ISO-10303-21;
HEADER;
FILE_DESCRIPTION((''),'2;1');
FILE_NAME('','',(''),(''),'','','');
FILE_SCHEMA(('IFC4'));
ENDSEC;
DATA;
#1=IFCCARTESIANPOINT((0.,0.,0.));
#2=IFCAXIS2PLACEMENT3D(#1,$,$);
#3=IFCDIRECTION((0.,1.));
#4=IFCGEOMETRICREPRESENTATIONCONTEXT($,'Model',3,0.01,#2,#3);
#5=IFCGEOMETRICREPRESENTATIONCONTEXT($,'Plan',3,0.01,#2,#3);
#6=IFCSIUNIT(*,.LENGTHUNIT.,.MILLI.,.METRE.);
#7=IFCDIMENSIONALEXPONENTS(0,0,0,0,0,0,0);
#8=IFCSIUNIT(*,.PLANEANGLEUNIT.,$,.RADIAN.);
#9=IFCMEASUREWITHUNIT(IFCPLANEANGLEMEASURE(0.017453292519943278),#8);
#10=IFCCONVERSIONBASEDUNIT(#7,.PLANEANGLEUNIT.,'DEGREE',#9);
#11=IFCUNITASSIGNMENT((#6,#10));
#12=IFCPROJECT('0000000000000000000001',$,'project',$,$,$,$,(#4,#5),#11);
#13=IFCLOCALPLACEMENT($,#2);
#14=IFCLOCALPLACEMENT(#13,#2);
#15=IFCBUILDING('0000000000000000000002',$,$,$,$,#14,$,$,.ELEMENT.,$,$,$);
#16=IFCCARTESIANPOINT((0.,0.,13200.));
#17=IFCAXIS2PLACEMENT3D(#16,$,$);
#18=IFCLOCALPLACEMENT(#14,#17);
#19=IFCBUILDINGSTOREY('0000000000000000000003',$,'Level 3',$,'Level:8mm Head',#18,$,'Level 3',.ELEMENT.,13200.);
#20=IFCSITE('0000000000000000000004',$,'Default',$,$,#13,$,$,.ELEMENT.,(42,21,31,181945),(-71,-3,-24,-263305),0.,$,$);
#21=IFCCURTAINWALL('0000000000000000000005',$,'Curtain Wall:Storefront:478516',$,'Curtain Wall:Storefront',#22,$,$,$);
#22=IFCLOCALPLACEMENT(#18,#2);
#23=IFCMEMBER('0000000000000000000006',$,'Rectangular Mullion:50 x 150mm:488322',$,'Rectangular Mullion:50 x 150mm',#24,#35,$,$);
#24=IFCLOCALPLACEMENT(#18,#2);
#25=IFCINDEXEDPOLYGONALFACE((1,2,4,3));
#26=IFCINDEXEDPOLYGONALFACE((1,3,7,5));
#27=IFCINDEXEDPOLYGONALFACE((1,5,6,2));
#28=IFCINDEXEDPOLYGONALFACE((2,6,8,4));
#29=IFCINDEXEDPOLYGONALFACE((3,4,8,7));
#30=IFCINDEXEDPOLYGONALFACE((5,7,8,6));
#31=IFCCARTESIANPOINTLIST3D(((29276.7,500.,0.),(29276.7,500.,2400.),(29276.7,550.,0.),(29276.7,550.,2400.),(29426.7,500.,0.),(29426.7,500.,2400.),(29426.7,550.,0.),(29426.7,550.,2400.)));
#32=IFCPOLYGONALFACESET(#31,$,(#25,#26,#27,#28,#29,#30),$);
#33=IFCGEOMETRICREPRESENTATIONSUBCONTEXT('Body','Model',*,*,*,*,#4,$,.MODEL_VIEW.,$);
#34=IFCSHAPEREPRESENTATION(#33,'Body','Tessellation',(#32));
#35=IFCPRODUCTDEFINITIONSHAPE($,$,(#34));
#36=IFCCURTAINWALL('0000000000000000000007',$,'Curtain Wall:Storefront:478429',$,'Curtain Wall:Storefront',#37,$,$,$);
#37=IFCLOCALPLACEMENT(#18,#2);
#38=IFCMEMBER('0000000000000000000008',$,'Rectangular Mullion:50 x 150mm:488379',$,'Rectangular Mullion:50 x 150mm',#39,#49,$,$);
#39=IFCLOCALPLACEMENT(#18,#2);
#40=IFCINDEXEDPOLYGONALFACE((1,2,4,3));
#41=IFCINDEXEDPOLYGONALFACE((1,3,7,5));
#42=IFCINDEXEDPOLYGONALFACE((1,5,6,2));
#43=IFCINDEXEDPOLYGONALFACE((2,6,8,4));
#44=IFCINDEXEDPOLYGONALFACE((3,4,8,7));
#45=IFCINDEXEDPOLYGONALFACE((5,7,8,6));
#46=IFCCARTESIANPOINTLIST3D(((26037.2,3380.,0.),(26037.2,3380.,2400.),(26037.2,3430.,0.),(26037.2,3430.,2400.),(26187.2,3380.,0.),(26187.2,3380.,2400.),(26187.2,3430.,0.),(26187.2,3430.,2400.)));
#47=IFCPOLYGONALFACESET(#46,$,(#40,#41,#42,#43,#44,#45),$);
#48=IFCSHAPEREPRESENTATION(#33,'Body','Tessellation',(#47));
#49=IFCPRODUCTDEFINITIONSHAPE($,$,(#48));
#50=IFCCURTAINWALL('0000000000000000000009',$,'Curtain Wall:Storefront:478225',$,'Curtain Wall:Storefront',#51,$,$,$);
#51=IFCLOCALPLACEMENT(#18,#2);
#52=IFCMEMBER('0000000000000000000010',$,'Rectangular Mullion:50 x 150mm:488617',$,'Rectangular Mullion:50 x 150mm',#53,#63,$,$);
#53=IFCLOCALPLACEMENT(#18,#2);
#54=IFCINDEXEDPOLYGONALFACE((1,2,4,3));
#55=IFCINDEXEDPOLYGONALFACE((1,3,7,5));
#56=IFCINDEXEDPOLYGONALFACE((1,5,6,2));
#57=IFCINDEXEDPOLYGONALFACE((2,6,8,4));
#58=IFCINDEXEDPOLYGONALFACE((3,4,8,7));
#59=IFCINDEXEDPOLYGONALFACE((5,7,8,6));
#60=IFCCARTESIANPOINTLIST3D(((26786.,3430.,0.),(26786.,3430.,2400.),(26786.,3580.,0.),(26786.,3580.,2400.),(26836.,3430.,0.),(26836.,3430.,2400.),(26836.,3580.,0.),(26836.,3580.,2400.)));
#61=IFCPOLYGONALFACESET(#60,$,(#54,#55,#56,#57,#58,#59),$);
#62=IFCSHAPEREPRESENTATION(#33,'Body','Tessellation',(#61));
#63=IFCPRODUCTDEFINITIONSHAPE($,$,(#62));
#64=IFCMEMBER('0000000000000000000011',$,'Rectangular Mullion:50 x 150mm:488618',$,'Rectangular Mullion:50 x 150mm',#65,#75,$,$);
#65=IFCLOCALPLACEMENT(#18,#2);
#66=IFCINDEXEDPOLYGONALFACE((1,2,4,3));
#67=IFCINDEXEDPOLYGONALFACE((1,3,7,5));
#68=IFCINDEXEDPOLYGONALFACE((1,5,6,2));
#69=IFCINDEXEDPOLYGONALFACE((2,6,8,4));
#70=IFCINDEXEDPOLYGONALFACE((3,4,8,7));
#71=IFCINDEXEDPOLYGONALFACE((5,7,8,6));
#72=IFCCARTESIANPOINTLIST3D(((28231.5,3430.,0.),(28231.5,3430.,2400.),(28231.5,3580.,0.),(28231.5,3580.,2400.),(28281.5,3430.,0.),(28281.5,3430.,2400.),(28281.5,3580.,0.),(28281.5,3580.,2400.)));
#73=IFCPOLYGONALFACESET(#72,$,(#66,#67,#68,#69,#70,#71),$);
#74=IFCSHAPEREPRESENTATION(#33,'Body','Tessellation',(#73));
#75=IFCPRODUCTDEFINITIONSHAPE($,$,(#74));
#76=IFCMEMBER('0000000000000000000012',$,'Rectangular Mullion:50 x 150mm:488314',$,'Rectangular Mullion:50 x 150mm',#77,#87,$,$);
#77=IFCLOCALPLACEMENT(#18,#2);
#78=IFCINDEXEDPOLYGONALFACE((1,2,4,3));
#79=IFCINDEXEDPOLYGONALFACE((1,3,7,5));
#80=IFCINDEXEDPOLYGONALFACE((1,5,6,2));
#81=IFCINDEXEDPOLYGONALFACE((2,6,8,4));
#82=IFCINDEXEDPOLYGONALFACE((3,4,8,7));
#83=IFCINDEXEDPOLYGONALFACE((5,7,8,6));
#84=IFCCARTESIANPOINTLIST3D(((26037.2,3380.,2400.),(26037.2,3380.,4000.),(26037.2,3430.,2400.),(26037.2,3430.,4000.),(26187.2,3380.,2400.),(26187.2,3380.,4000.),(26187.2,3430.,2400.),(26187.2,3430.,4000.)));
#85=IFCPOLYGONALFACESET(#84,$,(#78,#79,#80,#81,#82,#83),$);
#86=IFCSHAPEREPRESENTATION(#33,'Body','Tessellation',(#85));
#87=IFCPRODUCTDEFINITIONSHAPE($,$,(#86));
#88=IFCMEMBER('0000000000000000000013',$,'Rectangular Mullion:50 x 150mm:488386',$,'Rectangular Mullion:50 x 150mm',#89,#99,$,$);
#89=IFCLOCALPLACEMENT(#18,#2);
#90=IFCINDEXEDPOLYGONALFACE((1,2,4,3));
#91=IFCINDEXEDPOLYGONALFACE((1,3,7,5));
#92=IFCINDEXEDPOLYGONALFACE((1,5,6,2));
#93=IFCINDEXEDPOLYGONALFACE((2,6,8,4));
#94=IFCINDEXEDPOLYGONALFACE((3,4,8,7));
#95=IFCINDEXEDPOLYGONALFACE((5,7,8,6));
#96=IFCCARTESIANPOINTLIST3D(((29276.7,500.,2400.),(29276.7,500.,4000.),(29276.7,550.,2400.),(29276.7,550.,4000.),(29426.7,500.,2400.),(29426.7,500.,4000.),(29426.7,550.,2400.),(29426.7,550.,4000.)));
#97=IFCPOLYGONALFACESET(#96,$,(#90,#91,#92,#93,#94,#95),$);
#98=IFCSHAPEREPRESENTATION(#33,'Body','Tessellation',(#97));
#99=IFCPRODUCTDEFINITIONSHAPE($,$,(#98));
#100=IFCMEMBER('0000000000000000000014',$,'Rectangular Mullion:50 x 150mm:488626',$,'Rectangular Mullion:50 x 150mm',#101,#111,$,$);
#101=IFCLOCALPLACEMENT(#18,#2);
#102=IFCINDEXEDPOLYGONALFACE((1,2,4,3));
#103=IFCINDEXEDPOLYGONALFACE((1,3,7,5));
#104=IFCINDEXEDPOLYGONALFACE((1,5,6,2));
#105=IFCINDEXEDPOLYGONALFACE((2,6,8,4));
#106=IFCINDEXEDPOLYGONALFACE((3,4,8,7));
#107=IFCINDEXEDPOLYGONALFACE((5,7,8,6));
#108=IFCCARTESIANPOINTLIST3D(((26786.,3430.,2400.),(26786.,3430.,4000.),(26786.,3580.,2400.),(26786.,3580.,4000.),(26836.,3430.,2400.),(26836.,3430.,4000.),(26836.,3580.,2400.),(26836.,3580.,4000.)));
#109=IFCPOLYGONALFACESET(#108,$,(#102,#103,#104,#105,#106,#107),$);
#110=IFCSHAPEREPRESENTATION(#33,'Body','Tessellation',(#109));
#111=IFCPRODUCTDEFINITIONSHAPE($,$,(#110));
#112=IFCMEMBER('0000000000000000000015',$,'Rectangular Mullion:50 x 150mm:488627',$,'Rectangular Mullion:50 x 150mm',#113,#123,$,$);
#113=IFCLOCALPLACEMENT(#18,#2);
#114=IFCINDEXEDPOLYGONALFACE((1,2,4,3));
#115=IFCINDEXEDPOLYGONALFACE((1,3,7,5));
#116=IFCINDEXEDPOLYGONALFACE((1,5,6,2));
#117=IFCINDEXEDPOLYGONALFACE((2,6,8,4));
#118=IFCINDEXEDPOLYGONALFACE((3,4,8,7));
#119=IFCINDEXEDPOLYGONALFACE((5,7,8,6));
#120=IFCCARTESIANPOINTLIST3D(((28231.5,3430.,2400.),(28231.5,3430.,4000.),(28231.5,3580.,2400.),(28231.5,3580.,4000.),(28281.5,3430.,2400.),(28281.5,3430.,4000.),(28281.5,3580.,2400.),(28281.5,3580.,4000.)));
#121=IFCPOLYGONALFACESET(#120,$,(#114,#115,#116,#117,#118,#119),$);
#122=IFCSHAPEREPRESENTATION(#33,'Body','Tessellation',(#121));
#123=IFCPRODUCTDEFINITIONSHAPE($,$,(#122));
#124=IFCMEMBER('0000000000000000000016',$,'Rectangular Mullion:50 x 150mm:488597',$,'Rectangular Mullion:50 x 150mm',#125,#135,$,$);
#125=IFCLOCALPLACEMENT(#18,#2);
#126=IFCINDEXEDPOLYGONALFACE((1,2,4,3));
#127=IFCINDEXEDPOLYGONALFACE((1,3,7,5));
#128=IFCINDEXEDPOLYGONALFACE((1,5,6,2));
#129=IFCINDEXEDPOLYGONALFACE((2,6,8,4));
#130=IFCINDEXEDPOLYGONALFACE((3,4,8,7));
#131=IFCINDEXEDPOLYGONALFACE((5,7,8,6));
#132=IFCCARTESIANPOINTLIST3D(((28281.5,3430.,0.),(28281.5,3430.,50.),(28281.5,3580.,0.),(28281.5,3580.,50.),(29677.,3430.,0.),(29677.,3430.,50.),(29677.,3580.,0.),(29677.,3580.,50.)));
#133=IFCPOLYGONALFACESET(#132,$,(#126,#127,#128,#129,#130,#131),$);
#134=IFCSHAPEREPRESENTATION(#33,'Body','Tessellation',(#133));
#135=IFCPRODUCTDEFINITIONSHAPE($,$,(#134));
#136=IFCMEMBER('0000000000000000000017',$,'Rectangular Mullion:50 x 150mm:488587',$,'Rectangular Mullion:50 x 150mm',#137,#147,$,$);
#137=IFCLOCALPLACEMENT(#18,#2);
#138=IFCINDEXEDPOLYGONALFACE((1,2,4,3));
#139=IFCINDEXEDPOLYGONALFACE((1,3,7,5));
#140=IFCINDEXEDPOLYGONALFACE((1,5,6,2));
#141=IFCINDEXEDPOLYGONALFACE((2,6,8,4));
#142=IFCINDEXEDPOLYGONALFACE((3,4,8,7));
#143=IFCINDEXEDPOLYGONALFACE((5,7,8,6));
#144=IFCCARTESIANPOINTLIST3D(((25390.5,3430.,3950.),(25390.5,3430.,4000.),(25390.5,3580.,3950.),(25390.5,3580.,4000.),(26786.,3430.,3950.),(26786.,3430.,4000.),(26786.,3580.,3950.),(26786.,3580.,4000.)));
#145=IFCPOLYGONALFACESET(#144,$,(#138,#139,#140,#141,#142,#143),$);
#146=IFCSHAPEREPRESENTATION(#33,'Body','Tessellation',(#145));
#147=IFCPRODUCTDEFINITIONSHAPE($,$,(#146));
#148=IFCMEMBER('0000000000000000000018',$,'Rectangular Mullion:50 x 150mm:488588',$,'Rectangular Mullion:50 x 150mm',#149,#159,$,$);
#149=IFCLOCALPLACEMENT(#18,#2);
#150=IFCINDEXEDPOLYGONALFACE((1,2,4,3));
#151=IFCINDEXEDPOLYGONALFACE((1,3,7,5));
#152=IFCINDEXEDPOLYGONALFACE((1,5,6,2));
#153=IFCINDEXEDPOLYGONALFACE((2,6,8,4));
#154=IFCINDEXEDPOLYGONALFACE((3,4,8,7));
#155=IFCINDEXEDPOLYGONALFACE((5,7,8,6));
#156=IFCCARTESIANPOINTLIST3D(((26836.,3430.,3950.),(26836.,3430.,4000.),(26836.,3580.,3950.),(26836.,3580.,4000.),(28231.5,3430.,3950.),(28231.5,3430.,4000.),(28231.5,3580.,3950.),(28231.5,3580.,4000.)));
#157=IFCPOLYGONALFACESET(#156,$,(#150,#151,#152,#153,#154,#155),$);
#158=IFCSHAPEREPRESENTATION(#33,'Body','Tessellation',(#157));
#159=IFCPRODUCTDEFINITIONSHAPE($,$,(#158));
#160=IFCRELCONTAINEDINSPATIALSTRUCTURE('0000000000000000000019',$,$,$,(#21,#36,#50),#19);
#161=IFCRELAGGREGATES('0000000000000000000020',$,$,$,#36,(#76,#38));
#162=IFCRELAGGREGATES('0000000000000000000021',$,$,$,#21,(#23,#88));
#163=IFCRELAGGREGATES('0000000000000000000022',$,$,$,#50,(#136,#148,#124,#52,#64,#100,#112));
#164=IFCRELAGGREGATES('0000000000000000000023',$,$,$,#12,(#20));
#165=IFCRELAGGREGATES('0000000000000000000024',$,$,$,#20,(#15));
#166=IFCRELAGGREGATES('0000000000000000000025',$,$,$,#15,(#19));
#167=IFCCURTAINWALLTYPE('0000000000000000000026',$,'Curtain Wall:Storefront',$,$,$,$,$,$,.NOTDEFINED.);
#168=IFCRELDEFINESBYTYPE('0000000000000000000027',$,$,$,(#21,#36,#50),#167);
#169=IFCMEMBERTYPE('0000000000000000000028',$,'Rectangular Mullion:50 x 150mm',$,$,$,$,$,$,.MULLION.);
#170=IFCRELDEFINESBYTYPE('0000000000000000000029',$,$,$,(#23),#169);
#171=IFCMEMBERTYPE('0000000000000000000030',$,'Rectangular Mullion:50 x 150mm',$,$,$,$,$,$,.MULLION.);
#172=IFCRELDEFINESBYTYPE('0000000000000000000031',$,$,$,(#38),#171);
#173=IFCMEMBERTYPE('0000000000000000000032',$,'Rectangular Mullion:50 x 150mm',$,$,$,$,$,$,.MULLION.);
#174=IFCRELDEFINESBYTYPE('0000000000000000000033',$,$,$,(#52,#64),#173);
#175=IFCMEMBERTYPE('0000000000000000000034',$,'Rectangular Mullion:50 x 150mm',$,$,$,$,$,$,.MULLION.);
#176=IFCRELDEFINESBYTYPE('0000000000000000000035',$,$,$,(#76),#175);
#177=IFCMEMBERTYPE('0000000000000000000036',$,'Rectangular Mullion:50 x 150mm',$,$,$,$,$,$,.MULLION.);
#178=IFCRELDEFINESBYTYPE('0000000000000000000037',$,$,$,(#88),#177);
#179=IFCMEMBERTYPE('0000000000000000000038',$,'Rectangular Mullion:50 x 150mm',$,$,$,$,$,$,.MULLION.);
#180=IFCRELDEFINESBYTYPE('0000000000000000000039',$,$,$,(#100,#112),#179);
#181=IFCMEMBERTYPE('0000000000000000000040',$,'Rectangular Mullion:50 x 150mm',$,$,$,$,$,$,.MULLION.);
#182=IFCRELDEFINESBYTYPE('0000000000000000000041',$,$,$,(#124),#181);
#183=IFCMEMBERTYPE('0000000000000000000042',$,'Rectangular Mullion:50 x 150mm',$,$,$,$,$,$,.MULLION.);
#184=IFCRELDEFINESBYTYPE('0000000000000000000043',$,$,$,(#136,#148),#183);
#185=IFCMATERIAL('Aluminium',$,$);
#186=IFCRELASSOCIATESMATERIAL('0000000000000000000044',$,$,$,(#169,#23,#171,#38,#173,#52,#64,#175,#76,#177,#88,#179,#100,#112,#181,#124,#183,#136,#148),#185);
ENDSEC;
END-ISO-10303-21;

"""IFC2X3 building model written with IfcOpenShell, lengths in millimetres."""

from ifc_helpers import new_model, entity, si_unit, converted_unit, direction, frame, origin, origin_2d_with_axis, place, context, subcontext, project, spatial, rectangle, extrude, source, transform, mapped, material, type_object, type_shapes, element, aggregate, save


model = new_model("IFC2X3")

# Units and contexts
model_context = context("Model", 3, precision=0.01, world=origin(), true_north=direction((0.0, 1.0)))
plan_context = context("Plan", 3, precision=0.01, world=origin(), true_north=direction((0.0, 1.0)))
body_context = subcontext(model_context, "Body", "Model", "MODEL_VIEW")
ifc_project = project(units=[si_unit("LENGTHUNIT", "METRE", prefix="MILLI"), converted_unit("PLANEANGLEUNIT", "DEGREE", entity("IfcPlaneAngleMeasure", 0.017453292519943278), si_unit("PLANEANGLEUNIT", "RADIAN"), dimensions=[0, 0, 0, 0, 0, 0, 0])], contexts=[model_context, plan_context])

# Site, building, storey
site_placement = place(None, origin())
site = spatial("IfcSite", under=ifc_project, at=site_placement, Name="Default", CompositionType="ELEMENT", RefLatitude=(42, 21, 31, 181945), RefLongitude=(-71, -3, -24, -263305), RefElevation=0.0)
building_placement = place(site_placement, origin())
building = spatial("IfcBuilding", under=site, at=building_placement, CompositionType="ELEMENT")
storey_placement = place(building_placement, frame((0.0, 0.0, 13200.0)))
storey = spatial("IfcBuildingStorey", under=building, at=storey_placement, Name="Level 3", ObjectType="Level:8mm Head", LongName="Level 3", CompositionType="ELEMENT", Elevation=13200.0)

# Curtain walls, members
curtain_wall_type = type_object("IfcCurtainWallType", Name="Curtain Wall:Storefront", PredefinedType="NOTDEFINED")
curtain_wall_1_placement = place(storey_placement, frame((0.0, 0.0, -13200.0)))
curtain_wall_1 = element("IfcCurtainWall", 1, at=curtain_wall_1_placement, inside=storey, type_object=curtain_wall_type, Name="Curtain Wall:Storefront:478516", ObjectType="Curtain Wall:Storefront")
ifc_material_1 = material(Name="Aluminium")
member_type_1 = type_object("IfcMemberType", Name="Rectangular Mullion:50 x 150mm", PredefinedType="MULLION", material=ifc_material_1)
shared_shape_1 = source(origin(), body_context, "Body", "SweptSolid", [
    extrude(rectangle(XDim=50.0, YDim=150.0, at=origin_2d_with_axis()), frame((-25.0, 0.0, -2400.0), z_axis=(0.0, 0.0, 1.0), x_axis=(-1.0, 0.0, 0.0)), (0.0, 0.0, 1.0), 2400.0),
])
type_shapes(member_type_1, [shared_shape_1])
member_1_placement = place(curtain_wall_1_placement, frame((29351.7, 500.0, 13200.0), z_axis=(0.0, 0.0, -1.0), x_axis=(0.0, -1.0, 0.0)))
member_1 = element("IfcMember", 2, at=member_1_placement, type_object=member_type_1, material=ifc_material_1, Name="Rectangular Mullion:50 x 150mm:488322", ObjectType="Rectangular Mullion:50 x 150mm", context=body_context, shape_type="MappedRepresentation", body=[
    mapped(shared_shape_1, transform((0.0, 0.0, 0.0), scale=1.0)),
])
curtain_wall_2_placement = place(storey_placement, frame((0.0, 0.0, -13200.0)))
curtain_wall_2 = element("IfcCurtainWall", 3, at=curtain_wall_2_placement, inside=storey, type_object=curtain_wall_type, Name="Curtain Wall:Storefront:478429", ObjectType="Curtain Wall:Storefront")
member_type_2 = type_object("IfcMemberType", Name="Rectangular Mullion:50 x 150mm", PredefinedType="MULLION", material=ifc_material_1)
shared_shape_2 = source(origin(), body_context, "Body", "SweptSolid", [
    extrude(rectangle(XDim=50.0, YDim=150.0, at=origin_2d_with_axis()), frame((-25.0, 0.0, -2400.0), z_axis=(0.0, 0.0, 1.0), x_axis=(-1.0, 0.0, 0.0)), (0.0, 0.0, 1.0), 2400.0),
])
type_shapes(member_type_2, [shared_shape_2])
member_2_placement = place(curtain_wall_2_placement, frame((26112.2, 3430.0, 15600.0), z_axis=(0.0, 0.0, 1.0), x_axis=(0.0, 1.0, 0.0)))
member_2 = element("IfcMember", 4, at=member_2_placement, type_object=member_type_2, material=ifc_material_1, Name="Rectangular Mullion:50 x 150mm:488379", ObjectType="Rectangular Mullion:50 x 150mm", context=body_context, shape_type="MappedRepresentation", body=[
    mapped(shared_shape_2, transform((0.0, 0.0, 0.0), scale=1.0)),
])

# Curtain wall, members
curtain_wall_3_placement = place(storey_placement, frame((0.0, 0.0, -13200.0)))
curtain_wall_3 = element("IfcCurtainWall", 5, at=curtain_wall_3_placement, inside=storey, type_object=curtain_wall_type, Name="Curtain Wall:Storefront:478225", ObjectType="Curtain Wall:Storefront")
member_type_3 = type_object("IfcMemberType", Name="Rectangular Mullion:50 x 150mm", PredefinedType="MULLION", material=ifc_material_1)
shared_shape_3 = source(origin(), body_context, "Body", "SweptSolid", [
    extrude(rectangle(XDim=50.0, YDim=150.0, at=origin_2d_with_axis()), frame((0.0, 0.0, -2400.0), z_axis=(0.0, 0.0, 1.0), x_axis=(-1.0, 0.0, 0.0)), (0.0, 0.0, 1.0), 2400.0),
])
type_shapes(member_type_3, [shared_shape_3])
member_3_placement = place(curtain_wall_3_placement, frame((26811.0, 3505.0, 13200.0), z_axis=(0.0, 0.0, -1.0), x_axis=(1.0, 0.0, 0.0)))
member_3 = element("IfcMember", 6, at=member_3_placement, type_object=member_type_3, material=ifc_material_1, Name="Rectangular Mullion:50 x 150mm:488617", ObjectType="Rectangular Mullion:50 x 150mm", context=body_context, shape_type="MappedRepresentation", body=[
    mapped(shared_shape_3, transform((0.0, 0.0, 0.0), scale=1.0)),
])
member_4_placement = place(curtain_wall_3_placement, frame((28256.5, 3505.0, 13200.0), z_axis=(0.0, 0.0, -1.0), x_axis=(1.0, 0.0, 0.0)))
member_4 = element("IfcMember", 7, at=member_4_placement, type_object=member_type_3, material=ifc_material_1, Name="Rectangular Mullion:50 x 150mm:488618", ObjectType="Rectangular Mullion:50 x 150mm", context=body_context, shape_type="MappedRepresentation", body=[
    mapped(shared_shape_3, transform((0.0, 0.0, 0.0), scale=1.0)),
])

# Members
member_type_4 = type_object("IfcMemberType", Name="Rectangular Mullion:50 x 150mm", PredefinedType="MULLION", material=ifc_material_1)
shared_shape_4 = source(origin(), body_context, "Body", "SweptSolid", [
    extrude(rectangle(XDim=50.0, YDim=150.0, at=origin_2d_with_axis()), frame((-25.0, 0.0, -1600.0), z_axis=(0.0, 0.0, 1.0), x_axis=(-1.0, 0.0, 0.0)), (0.0, 0.0, 1.0), 1600.0),
])
type_shapes(member_type_4, [shared_shape_4])
member_5_placement = place(curtain_wall_2_placement, frame((26112.2, 3430.0, 17200.0), z_axis=(0.0, 0.0, 1.0), x_axis=(0.0, 1.0, 0.0)))
member_5 = element("IfcMember", 8, at=member_5_placement, type_object=member_type_4, material=ifc_material_1, Name="Rectangular Mullion:50 x 150mm:488314", ObjectType="Rectangular Mullion:50 x 150mm", context=body_context, shape_type="MappedRepresentation", body=[
    mapped(shared_shape_4, transform((0.0, 0.0, 0.0), scale=1.0)),
])
member_type_5 = type_object("IfcMemberType", Name="Rectangular Mullion:50 x 150mm", PredefinedType="MULLION", material=ifc_material_1)
shared_shape_5 = source(origin(), body_context, "Body", "SweptSolid", [
    extrude(rectangle(XDim=50.0, YDim=150.0, at=origin_2d_with_axis()), frame((-25.0, 0.0, -1600.0), z_axis=(0.0, 0.0, 1.0), x_axis=(-1.0, 0.0, 0.0)), (0.0, 0.0, 1.0), 1600.0),
])
type_shapes(member_type_5, [shared_shape_5])
member_6_placement = place(curtain_wall_1_placement, frame((29351.7, 500.0, 15600.0), z_axis=(0.0, 0.0, -1.0), x_axis=(0.0, -1.0, 0.0)))
member_6 = element("IfcMember", 9, at=member_6_placement, type_object=member_type_5, material=ifc_material_1, Name="Rectangular Mullion:50 x 150mm:488386", ObjectType="Rectangular Mullion:50 x 150mm", context=body_context, shape_type="MappedRepresentation", body=[
    mapped(shared_shape_5, transform((0.0, 0.0, 0.0), scale=1.0)),
])
member_type_6 = type_object("IfcMemberType", Name="Rectangular Mullion:50 x 150mm", PredefinedType="MULLION", material=ifc_material_1)
shared_shape_6 = source(origin(), body_context, "Body", "SweptSolid", [
    extrude(rectangle(XDim=50.0, YDim=150.0, at=origin_2d_with_axis()), frame((0.0, 0.0, -1600.0), z_axis=(0.0, 0.0, 1.0), x_axis=(-1.0, 0.0, 0.0)), (0.0, 0.0, 1.0), 1600.0),
])
type_shapes(member_type_6, [shared_shape_6])
member_7_placement = place(curtain_wall_3_placement, frame((26811.0, 3505.0, 15600.0), z_axis=(0.0, 0.0, -1.0), x_axis=(1.0, 0.0, 0.0)))
member_7 = element("IfcMember", 10, at=member_7_placement, type_object=member_type_6, material=ifc_material_1, Name="Rectangular Mullion:50 x 150mm:488626", ObjectType="Rectangular Mullion:50 x 150mm", context=body_context, shape_type="MappedRepresentation", body=[
    mapped(shared_shape_6, transform((0.0, 0.0, 0.0), scale=1.0)),
])
member_8_placement = place(curtain_wall_3_placement, frame((28256.5, 3505.0, 15600.0), z_axis=(0.0, 0.0, -1.0), x_axis=(1.0, 0.0, 0.0)))
member_8 = element("IfcMember", 11, at=member_8_placement, type_object=member_type_6, material=ifc_material_1, Name="Rectangular Mullion:50 x 150mm:488627", ObjectType="Rectangular Mullion:50 x 150mm", context=body_context, shape_type="MappedRepresentation", body=[
    mapped(shared_shape_6, transform((0.0, 0.0, 0.0), scale=1.0)),
])
member_type_7 = type_object("IfcMemberType", Name="Rectangular Mullion:50 x 150mm", PredefinedType="MULLION", material=ifc_material_1)
shared_shape_7 = source(origin(), body_context, "Body", "SweptSolid", [
    extrude(rectangle(XDim=50.0, YDim=150.0, at=origin_2d_with_axis()), frame((-25.0, 0.0, -1395.5), z_axis=(0.0, 0.0, 1.0), x_axis=(-1.0, 0.0, 0.0)), (0.0, 0.0, 1.0), 1395.5),
])
type_shapes(member_type_7, [shared_shape_7])
member_9_placement = place(curtain_wall_3_placement, frame((28281.5, 3505.0, 13200.0), z_axis=(-1.0, 0.0, 0.0), x_axis=(0.0, 0.0, -1.0)))
member_9 = element("IfcMember", 12, at=member_9_placement, type_object=member_type_7, material=ifc_material_1, Name="Rectangular Mullion:50 x 150mm:488597", ObjectType="Rectangular Mullion:50 x 150mm", context=body_context, shape_type="MappedRepresentation", body=[
    mapped(shared_shape_7, transform((0.0, 0.0, 0.0), scale=1.0)),
])
member_type_8 = type_object("IfcMemberType", Name="Rectangular Mullion:50 x 150mm", PredefinedType="MULLION", material=ifc_material_1)
shared_shape_8 = source(origin(), body_context, "Body", "SweptSolid", [
    extrude(rectangle(XDim=50.0, YDim=150.0, at=origin_2d_with_axis()), frame((-25.0, 0.0, -1395.5), z_axis=(0.0, 0.0, 1.0), x_axis=(-1.0, 0.0, 0.0)), (0.0, 0.0, 1.0), 1395.5),
])
type_shapes(member_type_8, [shared_shape_8])
member_10_placement = place(curtain_wall_3_placement, frame((26786.0, 3505.0, 17200.0), z_axis=(1.0, 0.0, 0.0), x_axis=(0.0, 0.0, 1.0)))
member_10 = element("IfcMember", 13, at=member_10_placement, type_object=member_type_8, material=ifc_material_1, Name="Rectangular Mullion:50 x 150mm:488587", ObjectType="Rectangular Mullion:50 x 150mm", context=body_context, shape_type="MappedRepresentation", body=[
    mapped(shared_shape_8, transform((0.0, 0.0, 0.0), scale=1.0)),
])
member_11_placement = place(curtain_wall_3_placement, frame((28231.5, 3505.0, 17200.0), z_axis=(1.0, 0.0, 0.0), x_axis=(0.0, 0.0, 1.0)))
member_11 = element("IfcMember", 14, at=member_11_placement, type_object=member_type_8, material=ifc_material_1, Name="Rectangular Mullion:50 x 150mm:488588", ObjectType="Rectangular Mullion:50 x 150mm", context=body_context, shape_type="MappedRepresentation", body=[
    mapped(shared_shape_8, transform((0.0, 0.0, 0.0), scale=1.0)),
])

aggregate(curtain_wall_2, [member_5, member_2])
aggregate(curtain_wall_1, [member_1, member_6])

aggregate(curtain_wall_3, [member_10, member_11, member_9, member_3, member_4, member_7, member_8])

save(model, "model.ifc")
